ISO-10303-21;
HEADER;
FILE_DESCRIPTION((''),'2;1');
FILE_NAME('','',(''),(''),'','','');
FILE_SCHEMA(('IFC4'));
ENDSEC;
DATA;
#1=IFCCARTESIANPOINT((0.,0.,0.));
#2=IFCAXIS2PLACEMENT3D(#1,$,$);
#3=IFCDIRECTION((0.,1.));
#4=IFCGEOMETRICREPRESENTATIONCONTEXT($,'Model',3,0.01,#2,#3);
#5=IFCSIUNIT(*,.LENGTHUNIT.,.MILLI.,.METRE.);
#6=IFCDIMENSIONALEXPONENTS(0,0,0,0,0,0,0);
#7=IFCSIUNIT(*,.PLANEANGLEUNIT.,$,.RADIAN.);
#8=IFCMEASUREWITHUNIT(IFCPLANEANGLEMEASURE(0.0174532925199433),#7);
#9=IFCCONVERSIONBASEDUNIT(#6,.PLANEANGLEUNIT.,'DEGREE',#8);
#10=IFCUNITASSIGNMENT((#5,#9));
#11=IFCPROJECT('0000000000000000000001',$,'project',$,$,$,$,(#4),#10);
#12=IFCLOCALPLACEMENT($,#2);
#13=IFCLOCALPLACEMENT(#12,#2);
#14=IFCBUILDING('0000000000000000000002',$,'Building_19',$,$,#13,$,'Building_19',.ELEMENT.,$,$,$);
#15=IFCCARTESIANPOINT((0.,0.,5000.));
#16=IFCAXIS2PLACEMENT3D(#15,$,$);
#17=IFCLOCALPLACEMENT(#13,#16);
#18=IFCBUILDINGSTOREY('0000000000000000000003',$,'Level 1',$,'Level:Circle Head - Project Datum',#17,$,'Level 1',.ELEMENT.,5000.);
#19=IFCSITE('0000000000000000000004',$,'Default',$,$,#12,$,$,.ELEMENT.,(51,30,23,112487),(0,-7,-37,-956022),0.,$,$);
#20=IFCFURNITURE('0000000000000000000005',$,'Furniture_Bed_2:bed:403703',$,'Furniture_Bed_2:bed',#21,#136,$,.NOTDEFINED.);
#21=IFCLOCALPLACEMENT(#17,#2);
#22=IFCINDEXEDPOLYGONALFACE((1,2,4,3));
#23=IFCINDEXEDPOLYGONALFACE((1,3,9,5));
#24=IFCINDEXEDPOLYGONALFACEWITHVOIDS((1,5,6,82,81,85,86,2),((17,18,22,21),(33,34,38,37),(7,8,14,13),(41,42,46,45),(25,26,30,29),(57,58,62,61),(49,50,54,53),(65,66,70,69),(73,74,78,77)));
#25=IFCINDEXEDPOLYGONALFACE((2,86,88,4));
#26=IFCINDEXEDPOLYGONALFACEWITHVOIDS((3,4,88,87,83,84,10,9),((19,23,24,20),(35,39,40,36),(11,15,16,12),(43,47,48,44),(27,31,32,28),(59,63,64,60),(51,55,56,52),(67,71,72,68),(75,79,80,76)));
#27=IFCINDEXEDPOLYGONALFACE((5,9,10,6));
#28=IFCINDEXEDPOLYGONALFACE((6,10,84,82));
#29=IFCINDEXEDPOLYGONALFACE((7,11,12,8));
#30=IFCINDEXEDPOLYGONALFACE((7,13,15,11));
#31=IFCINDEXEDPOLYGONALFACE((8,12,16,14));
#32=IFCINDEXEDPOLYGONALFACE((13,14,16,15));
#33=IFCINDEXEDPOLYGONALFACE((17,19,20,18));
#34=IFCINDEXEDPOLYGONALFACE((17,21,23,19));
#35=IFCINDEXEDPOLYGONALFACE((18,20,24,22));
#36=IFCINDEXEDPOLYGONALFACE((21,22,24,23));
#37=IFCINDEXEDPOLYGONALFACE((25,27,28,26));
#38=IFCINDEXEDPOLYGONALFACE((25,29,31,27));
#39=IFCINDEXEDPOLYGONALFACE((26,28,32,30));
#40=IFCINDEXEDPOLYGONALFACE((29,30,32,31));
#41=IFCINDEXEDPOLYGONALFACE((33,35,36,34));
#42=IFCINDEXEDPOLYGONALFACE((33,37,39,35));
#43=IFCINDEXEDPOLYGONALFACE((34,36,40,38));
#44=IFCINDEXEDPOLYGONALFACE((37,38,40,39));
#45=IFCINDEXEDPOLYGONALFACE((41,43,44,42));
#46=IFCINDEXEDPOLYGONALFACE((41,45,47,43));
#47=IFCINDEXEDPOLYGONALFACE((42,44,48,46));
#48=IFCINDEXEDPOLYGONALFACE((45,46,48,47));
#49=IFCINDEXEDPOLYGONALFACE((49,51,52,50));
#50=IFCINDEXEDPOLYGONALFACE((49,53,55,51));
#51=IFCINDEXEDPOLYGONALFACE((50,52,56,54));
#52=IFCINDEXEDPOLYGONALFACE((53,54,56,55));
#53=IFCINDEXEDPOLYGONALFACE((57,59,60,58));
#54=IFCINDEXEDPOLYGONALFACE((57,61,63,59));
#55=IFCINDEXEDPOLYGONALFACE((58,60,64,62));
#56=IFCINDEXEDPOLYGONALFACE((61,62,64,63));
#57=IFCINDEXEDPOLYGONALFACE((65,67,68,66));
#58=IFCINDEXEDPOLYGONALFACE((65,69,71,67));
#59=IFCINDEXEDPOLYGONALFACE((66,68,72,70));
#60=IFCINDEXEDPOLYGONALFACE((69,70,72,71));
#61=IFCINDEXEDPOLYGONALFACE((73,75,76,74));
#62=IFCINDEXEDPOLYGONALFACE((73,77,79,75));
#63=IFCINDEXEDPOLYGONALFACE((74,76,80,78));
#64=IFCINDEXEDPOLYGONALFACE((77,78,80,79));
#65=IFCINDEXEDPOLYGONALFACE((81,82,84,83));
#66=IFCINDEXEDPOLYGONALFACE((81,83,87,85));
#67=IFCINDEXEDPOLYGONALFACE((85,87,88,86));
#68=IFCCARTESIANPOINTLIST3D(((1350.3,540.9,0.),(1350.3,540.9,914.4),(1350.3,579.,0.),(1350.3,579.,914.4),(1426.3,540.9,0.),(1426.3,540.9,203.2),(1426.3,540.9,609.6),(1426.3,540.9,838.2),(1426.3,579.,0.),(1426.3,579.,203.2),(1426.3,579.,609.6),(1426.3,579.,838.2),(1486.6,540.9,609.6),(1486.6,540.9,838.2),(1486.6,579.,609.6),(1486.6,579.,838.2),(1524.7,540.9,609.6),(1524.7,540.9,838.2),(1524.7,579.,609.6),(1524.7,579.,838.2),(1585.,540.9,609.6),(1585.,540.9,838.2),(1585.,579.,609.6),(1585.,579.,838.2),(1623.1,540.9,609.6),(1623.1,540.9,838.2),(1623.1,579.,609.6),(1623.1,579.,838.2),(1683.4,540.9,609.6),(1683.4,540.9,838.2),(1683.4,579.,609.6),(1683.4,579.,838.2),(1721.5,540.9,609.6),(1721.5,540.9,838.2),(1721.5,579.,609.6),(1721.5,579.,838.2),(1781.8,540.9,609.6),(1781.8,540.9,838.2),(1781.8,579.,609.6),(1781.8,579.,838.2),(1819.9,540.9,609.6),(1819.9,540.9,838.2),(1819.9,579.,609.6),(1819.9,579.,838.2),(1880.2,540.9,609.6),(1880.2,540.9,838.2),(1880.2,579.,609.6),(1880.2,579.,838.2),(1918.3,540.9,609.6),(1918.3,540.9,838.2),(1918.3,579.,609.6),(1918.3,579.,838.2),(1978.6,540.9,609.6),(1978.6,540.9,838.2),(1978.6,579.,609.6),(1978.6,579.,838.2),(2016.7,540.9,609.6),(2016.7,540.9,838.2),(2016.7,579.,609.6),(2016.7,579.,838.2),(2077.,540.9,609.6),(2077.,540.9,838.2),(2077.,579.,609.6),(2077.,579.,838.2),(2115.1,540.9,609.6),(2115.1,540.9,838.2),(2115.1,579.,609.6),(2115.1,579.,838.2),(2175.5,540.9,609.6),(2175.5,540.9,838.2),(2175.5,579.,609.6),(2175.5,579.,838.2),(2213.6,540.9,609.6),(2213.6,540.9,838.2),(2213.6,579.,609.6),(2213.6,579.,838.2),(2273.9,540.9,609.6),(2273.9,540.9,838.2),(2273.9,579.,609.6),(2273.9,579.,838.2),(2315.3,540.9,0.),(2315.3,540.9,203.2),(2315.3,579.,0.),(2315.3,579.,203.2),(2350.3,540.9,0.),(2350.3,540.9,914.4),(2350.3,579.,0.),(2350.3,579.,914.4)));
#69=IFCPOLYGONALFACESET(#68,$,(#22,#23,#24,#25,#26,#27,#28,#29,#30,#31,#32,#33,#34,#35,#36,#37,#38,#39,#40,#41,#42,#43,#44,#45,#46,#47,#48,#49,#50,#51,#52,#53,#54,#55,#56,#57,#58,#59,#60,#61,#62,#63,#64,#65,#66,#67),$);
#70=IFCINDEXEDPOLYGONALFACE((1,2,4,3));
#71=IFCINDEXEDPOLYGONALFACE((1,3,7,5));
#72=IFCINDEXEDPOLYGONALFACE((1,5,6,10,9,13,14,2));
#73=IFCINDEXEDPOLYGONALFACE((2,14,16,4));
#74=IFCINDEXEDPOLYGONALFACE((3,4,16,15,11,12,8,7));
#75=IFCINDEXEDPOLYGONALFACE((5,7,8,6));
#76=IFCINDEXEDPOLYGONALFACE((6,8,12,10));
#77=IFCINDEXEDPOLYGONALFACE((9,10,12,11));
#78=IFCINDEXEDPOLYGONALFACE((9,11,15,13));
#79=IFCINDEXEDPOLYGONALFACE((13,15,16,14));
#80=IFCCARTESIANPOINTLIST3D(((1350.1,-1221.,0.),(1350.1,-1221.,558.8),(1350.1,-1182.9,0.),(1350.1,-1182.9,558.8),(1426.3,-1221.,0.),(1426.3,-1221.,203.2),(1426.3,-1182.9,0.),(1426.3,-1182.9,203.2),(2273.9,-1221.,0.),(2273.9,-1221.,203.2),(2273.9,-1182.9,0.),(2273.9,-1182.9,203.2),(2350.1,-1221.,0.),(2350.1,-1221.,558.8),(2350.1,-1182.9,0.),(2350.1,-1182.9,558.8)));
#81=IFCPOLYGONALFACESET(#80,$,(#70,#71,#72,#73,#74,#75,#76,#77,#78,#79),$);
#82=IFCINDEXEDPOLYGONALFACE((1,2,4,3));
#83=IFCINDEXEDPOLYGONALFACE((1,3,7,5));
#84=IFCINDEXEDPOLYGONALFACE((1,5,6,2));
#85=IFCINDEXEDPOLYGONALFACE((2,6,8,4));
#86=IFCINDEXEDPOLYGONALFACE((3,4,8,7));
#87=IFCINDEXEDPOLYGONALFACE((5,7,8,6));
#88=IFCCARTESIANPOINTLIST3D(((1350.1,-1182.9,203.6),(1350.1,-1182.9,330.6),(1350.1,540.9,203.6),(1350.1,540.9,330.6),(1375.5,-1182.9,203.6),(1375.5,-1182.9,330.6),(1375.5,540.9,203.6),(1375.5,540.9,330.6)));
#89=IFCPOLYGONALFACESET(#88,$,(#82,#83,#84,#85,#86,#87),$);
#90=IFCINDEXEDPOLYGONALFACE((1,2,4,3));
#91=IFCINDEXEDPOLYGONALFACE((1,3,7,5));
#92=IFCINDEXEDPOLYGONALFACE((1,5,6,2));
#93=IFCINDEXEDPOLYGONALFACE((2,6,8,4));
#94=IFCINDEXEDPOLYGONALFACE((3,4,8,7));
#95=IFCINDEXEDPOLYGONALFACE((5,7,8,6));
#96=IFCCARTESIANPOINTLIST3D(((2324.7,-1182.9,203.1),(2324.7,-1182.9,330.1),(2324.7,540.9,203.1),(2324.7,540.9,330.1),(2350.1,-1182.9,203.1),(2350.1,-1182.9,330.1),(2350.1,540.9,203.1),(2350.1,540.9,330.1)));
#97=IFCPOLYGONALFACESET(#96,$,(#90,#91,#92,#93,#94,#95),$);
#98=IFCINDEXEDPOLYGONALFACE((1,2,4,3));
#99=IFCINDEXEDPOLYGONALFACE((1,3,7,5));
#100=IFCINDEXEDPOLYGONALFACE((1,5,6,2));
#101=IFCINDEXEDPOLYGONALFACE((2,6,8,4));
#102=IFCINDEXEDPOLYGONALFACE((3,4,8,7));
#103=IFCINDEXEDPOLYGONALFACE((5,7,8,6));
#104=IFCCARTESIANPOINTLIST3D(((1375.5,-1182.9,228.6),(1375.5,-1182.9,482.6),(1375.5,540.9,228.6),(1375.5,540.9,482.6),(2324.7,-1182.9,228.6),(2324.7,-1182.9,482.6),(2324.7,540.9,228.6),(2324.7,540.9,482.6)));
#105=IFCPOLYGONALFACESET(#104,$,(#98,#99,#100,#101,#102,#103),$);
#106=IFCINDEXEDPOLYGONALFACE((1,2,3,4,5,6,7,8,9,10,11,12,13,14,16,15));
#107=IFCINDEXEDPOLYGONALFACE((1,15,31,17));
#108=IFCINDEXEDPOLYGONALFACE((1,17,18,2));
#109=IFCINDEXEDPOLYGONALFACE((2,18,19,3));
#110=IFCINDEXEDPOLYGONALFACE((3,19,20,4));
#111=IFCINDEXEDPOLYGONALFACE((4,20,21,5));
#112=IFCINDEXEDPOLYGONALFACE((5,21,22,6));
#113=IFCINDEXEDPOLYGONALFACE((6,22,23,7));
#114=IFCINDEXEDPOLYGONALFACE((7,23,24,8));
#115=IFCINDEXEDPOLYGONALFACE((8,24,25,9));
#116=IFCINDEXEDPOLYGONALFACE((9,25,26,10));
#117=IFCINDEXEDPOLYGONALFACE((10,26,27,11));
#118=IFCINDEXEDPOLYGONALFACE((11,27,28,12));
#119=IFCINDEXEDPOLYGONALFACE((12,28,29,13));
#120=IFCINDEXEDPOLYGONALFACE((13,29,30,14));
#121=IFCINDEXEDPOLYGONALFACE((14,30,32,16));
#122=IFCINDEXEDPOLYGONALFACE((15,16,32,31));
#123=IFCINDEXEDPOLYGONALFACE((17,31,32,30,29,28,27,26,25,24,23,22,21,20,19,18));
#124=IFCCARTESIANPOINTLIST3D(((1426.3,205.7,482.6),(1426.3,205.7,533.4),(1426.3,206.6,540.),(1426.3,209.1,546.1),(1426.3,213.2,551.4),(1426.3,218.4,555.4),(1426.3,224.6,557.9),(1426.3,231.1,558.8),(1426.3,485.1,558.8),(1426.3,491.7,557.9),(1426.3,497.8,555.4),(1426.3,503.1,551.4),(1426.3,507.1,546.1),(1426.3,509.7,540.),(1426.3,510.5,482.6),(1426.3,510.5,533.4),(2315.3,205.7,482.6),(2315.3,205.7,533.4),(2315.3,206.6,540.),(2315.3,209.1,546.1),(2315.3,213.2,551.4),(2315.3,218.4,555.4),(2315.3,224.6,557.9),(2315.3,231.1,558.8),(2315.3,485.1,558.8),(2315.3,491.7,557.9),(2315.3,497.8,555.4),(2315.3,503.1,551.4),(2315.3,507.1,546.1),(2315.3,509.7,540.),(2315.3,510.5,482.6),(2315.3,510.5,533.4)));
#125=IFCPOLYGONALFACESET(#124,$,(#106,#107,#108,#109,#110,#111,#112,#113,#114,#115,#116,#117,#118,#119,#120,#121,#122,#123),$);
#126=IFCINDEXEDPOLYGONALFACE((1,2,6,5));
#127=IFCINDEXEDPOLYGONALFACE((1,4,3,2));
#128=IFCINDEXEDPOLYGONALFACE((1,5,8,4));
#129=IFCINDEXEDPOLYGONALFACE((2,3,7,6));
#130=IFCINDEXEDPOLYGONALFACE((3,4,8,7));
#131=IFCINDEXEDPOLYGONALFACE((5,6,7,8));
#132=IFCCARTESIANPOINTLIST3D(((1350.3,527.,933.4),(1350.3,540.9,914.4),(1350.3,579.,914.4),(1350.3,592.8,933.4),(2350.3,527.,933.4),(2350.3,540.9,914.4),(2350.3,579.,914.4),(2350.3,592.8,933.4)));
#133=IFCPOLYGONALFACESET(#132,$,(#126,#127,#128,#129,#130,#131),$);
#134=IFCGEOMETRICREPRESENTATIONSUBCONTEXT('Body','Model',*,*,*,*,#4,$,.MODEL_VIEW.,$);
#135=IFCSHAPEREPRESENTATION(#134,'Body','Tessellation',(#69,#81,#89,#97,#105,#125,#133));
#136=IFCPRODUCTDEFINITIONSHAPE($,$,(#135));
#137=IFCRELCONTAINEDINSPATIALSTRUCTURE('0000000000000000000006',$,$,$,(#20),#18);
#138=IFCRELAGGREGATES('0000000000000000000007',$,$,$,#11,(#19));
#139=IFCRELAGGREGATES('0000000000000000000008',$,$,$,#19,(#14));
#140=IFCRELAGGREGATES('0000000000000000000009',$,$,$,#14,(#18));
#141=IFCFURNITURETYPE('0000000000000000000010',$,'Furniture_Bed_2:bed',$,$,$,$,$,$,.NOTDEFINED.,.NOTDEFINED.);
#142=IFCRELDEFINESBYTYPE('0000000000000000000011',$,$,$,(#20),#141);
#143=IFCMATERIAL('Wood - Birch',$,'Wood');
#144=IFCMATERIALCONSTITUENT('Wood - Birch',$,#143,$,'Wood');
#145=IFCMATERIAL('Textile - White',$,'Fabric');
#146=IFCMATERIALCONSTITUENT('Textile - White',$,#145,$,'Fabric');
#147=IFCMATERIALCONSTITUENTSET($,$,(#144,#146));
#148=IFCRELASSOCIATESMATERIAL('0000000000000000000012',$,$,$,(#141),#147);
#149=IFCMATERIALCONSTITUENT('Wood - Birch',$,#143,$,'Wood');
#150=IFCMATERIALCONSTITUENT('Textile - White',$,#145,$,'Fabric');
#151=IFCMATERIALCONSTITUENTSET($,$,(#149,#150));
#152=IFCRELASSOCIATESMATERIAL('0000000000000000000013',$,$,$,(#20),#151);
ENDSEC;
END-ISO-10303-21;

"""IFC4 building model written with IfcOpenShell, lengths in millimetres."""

from ifc_helpers import new_model, entity, si_unit, converted_unit, direction, frame, origin, place, context, subcontext, project, spatial, line, arc, indexed_curve, outline, extrude, source, transform, mapped, material, constituent, constituent_set, type_object, type_shapes, element, save


model = new_model("IFC4")

# Units and contexts
model_context = context("Model", 3, precision=0.01, world=origin(), true_north=direction((0.0, 1.0)))
body_context = subcontext(model_context, "Body", "Model", "MODEL_VIEW")
ifc_project = project(units=[si_unit("LENGTHUNIT", "METRE", prefix="MILLI"), converted_unit("PLANEANGLEUNIT", "DEGREE", entity("IfcPlaneAngleMeasure", 0.0174532925199433), si_unit("PLANEANGLEUNIT", "RADIAN"), dimensions=[0, 0, 0, 0, 0, 0, 0])], contexts=[model_context])

# Site, building, storey
site_placement = place(None, origin())
site = spatial("IfcSite", under=ifc_project, at=site_placement, Name="Default", CompositionType="ELEMENT", RefLatitude=(51, 30, 23, 112487), RefLongitude=(0, -7, -37, -956022), RefElevation=0.0)
building_placement = place(site_placement, origin())
building = spatial("IfcBuilding", under=site, at=building_placement, Name="Building_19", LongName="Building_19", CompositionType="ELEMENT")
storey_placement = place(building_placement, frame((0.0, 0.0, 5000.0)))
storey = spatial("IfcBuildingStorey", under=building, at=storey_placement, Name="Level 1", ObjectType="Level:Circle Head - Project Datum", LongName="Level 1", CompositionType="ELEMENT", Elevation=5000.0)

# Furniture
ifc_material_1 = material(Name="Wood - Birch", Category="Wood")
ifc_material_2 = material(Name="Textile - White", Category="Fabric")
ifc_constituent_1 = constituent(ifc_material_1, Name="Wood - Birch", Category="Wood")
ifc_constituent_2 = constituent(ifc_material_2, Name="Textile - White", Category="Fabric")
ifc_constituent_set_1 = constituent_set(constituents=[ifc_constituent_1, ifc_constituent_2])
furniture_type_1 = type_object("IfcFurnitureType", Name="Furniture_Bed_2:bed", AssemblyPlace="NOTDEFINED", PredefinedType="NOTDEFINED", material=ifc_constituent_set_1)
shared_shape_1 = source(origin(), body_context, "Body", "SweptSolid", [
    extrude(outline(indexed_curve([(-635.0, -489.8), (279.4, -489.8), (279.4, -454.7), (76.2, -454.7), (76.2, 434.3), (279.4, 434.3), (279.4, 510.3), (-635.0, 510.3), (-635.0, -489.8)], self_intersect=False), holes=[indexed_curve([(-558.8, 374.0), (-558.8, 434.3), (-330.2, 434.3), (-330.2, 374.0), (-558.8, 374.0)], self_intersect=False), indexed_curve([(-558.8, 275.5), (-558.8, 335.9), (-330.2, 335.9), (-330.2, 275.5), (-558.8, 275.5)], self_intersect=False), indexed_curve([(-558.8, 177.1), (-558.8, 237.4), (-330.2, 237.4), (-330.2, 177.1), (-558.8, 177.1)], self_intersect=False), indexed_curve([(-558.8, 78.7), (-558.8, 139.0), (-330.2, 139.0), (-330.2, 78.7), (-558.8, 78.7)], self_intersect=False), indexed_curve([(-558.8, -118.1), (-558.8, -57.8), (-330.2, -57.8), (-330.2, -118.1), (-558.8, -118.1)], self_intersect=False), indexed_curve([(-558.8, -216.5), (-558.8, -156.2), (-330.2, -156.2), (-330.2, -216.5), (-558.8, -216.5)], self_intersect=False), indexed_curve([(-558.8, -314.9), (-558.8, -254.6), (-330.2, -254.6), (-330.2, -314.9), (-558.8, -314.9)], self_intersect=False), indexed_curve([(-558.8, -413.3), (-558.8, -353.0), (-330.2, -353.0), (-330.2, -413.3), (-558.8, -413.3)], self_intersect=False), indexed_curve([(-558.8, -19.7), (-558.8, 40.6), (-330.2, 40.6), (-330.2, -19.7), (-558.8, -19.7)], self_intersect=False)]), frame((-8.6, -38.1, 279.4), z_axis=(0.0, 1.0, 0.0), x_axis=(0.0, 0.0, -1.0)), (0.0, 0.0, 1.0), 38.1),
    extrude(outline(indexed_curve([(423.8, -190.5), (500.0, -190.5), (500.0, 368.3), (-500.0, 368.3), (-500.0, -190.5), (-423.8, -190.5), (-423.8, 12.7), (423.8, 12.7), (423.8, -190.5)], self_intersect=False)), frame((-19.1, -1800.0, 190.5), z_axis=(0.0, 1.0, 0.0), x_axis=(-1.0, 0.0, 0.0)), (0.0, 0.0, 1.0), 38.1),
    extrude(outline(indexed_curve([(-12.7, -861.9), (12.7, -861.9), (12.7, 861.9), (-12.7, 861.9), (-12.7, -861.9)], self_intersect=False)), frame((-506.4, -900.0, 203.6)), (0.0, 0.0, 1.0), 127.0),
    extrude(outline(indexed_curve([(-12.7, -861.9), (12.7, -861.9), (12.7, 861.9), (-12.7, 861.9), (-12.7, -861.9)], self_intersect=False)), frame((468.2, -900.0, 203.1)), (0.0, 0.0, 1.0), 127.0),
    extrude(outline(indexed_curve([(-474.6, -861.9), (474.6, -861.9), (474.6, 861.9), (-474.6, 861.9), (-474.6, -861.9)], self_intersect=False)), frame((-19.0, -900.0, 228.6), z_axis=(0.0, 0.0, 1.0), x_axis=(-1.0, 0.0, 0.0)), (0.0, 0.0, 1.0), 254.0),
    extrude(outline(indexed_curve([(-152.4, -42.3), (152.4, -42.3), (152.4, 8.5), (145.0, 26.4), (127.0, 33.9), (-127.0, 33.9), (-145.0, 26.4), (-152.4, 8.5)], segments=[line(1, 2, 3), arc(3, 4, 5), line(5, 6), arc(6, 7, 8), line(8, 1)], self_intersect=False)), frame((-442.9, -220.8, 524.9), z_axis=(1.0, 0.0, 0.0), x_axis=(0.0, 1.0, 0.0)), (0.0, 0.0, 1.0), 889.0),
    extrude(outline(indexed_curve([(-19.1, -9.5), (19.0, -9.5), (32.9, 9.5), (-32.9, 9.5), (-19.1, -9.5)], self_intersect=False)), frame((-518.8, -19.0, 923.9), z_axis=(1.0, 0.0, 0.0), x_axis=(0.0, 1.0, 0.0)), (0.0, 0.0, 1.0), 1000.1),
])
type_shapes(furniture_type_1, [shared_shape_1])
ifc_constituent_3 = constituent(ifc_material_1, Name="Wood - Birch", Category="Wood")
ifc_constituent_4 = constituent(ifc_material_2, Name="Textile - White", Category="Fabric")
ifc_constituent_set_2 = constituent_set(constituents=[ifc_constituent_3, ifc_constituent_4])
furniture_1_placement = place(storey_placement, frame((1869.1, 579.0, 0.0)))
element("IfcFurniture", 1, at=furniture_1_placement, inside=storey, type_object=furniture_type_1, material=ifc_constituent_set_2, Name="Furniture_Bed_2:bed:403703", ObjectType="Furniture_Bed_2:bed", PredefinedType="NOTDEFINED", context=body_context, shape_type="MappedRepresentation", body=[
    mapped(shared_shape_1, transform((0.0, 0.0, 0.0), scale=1.0)),
])

save(model, "model.ifc")
